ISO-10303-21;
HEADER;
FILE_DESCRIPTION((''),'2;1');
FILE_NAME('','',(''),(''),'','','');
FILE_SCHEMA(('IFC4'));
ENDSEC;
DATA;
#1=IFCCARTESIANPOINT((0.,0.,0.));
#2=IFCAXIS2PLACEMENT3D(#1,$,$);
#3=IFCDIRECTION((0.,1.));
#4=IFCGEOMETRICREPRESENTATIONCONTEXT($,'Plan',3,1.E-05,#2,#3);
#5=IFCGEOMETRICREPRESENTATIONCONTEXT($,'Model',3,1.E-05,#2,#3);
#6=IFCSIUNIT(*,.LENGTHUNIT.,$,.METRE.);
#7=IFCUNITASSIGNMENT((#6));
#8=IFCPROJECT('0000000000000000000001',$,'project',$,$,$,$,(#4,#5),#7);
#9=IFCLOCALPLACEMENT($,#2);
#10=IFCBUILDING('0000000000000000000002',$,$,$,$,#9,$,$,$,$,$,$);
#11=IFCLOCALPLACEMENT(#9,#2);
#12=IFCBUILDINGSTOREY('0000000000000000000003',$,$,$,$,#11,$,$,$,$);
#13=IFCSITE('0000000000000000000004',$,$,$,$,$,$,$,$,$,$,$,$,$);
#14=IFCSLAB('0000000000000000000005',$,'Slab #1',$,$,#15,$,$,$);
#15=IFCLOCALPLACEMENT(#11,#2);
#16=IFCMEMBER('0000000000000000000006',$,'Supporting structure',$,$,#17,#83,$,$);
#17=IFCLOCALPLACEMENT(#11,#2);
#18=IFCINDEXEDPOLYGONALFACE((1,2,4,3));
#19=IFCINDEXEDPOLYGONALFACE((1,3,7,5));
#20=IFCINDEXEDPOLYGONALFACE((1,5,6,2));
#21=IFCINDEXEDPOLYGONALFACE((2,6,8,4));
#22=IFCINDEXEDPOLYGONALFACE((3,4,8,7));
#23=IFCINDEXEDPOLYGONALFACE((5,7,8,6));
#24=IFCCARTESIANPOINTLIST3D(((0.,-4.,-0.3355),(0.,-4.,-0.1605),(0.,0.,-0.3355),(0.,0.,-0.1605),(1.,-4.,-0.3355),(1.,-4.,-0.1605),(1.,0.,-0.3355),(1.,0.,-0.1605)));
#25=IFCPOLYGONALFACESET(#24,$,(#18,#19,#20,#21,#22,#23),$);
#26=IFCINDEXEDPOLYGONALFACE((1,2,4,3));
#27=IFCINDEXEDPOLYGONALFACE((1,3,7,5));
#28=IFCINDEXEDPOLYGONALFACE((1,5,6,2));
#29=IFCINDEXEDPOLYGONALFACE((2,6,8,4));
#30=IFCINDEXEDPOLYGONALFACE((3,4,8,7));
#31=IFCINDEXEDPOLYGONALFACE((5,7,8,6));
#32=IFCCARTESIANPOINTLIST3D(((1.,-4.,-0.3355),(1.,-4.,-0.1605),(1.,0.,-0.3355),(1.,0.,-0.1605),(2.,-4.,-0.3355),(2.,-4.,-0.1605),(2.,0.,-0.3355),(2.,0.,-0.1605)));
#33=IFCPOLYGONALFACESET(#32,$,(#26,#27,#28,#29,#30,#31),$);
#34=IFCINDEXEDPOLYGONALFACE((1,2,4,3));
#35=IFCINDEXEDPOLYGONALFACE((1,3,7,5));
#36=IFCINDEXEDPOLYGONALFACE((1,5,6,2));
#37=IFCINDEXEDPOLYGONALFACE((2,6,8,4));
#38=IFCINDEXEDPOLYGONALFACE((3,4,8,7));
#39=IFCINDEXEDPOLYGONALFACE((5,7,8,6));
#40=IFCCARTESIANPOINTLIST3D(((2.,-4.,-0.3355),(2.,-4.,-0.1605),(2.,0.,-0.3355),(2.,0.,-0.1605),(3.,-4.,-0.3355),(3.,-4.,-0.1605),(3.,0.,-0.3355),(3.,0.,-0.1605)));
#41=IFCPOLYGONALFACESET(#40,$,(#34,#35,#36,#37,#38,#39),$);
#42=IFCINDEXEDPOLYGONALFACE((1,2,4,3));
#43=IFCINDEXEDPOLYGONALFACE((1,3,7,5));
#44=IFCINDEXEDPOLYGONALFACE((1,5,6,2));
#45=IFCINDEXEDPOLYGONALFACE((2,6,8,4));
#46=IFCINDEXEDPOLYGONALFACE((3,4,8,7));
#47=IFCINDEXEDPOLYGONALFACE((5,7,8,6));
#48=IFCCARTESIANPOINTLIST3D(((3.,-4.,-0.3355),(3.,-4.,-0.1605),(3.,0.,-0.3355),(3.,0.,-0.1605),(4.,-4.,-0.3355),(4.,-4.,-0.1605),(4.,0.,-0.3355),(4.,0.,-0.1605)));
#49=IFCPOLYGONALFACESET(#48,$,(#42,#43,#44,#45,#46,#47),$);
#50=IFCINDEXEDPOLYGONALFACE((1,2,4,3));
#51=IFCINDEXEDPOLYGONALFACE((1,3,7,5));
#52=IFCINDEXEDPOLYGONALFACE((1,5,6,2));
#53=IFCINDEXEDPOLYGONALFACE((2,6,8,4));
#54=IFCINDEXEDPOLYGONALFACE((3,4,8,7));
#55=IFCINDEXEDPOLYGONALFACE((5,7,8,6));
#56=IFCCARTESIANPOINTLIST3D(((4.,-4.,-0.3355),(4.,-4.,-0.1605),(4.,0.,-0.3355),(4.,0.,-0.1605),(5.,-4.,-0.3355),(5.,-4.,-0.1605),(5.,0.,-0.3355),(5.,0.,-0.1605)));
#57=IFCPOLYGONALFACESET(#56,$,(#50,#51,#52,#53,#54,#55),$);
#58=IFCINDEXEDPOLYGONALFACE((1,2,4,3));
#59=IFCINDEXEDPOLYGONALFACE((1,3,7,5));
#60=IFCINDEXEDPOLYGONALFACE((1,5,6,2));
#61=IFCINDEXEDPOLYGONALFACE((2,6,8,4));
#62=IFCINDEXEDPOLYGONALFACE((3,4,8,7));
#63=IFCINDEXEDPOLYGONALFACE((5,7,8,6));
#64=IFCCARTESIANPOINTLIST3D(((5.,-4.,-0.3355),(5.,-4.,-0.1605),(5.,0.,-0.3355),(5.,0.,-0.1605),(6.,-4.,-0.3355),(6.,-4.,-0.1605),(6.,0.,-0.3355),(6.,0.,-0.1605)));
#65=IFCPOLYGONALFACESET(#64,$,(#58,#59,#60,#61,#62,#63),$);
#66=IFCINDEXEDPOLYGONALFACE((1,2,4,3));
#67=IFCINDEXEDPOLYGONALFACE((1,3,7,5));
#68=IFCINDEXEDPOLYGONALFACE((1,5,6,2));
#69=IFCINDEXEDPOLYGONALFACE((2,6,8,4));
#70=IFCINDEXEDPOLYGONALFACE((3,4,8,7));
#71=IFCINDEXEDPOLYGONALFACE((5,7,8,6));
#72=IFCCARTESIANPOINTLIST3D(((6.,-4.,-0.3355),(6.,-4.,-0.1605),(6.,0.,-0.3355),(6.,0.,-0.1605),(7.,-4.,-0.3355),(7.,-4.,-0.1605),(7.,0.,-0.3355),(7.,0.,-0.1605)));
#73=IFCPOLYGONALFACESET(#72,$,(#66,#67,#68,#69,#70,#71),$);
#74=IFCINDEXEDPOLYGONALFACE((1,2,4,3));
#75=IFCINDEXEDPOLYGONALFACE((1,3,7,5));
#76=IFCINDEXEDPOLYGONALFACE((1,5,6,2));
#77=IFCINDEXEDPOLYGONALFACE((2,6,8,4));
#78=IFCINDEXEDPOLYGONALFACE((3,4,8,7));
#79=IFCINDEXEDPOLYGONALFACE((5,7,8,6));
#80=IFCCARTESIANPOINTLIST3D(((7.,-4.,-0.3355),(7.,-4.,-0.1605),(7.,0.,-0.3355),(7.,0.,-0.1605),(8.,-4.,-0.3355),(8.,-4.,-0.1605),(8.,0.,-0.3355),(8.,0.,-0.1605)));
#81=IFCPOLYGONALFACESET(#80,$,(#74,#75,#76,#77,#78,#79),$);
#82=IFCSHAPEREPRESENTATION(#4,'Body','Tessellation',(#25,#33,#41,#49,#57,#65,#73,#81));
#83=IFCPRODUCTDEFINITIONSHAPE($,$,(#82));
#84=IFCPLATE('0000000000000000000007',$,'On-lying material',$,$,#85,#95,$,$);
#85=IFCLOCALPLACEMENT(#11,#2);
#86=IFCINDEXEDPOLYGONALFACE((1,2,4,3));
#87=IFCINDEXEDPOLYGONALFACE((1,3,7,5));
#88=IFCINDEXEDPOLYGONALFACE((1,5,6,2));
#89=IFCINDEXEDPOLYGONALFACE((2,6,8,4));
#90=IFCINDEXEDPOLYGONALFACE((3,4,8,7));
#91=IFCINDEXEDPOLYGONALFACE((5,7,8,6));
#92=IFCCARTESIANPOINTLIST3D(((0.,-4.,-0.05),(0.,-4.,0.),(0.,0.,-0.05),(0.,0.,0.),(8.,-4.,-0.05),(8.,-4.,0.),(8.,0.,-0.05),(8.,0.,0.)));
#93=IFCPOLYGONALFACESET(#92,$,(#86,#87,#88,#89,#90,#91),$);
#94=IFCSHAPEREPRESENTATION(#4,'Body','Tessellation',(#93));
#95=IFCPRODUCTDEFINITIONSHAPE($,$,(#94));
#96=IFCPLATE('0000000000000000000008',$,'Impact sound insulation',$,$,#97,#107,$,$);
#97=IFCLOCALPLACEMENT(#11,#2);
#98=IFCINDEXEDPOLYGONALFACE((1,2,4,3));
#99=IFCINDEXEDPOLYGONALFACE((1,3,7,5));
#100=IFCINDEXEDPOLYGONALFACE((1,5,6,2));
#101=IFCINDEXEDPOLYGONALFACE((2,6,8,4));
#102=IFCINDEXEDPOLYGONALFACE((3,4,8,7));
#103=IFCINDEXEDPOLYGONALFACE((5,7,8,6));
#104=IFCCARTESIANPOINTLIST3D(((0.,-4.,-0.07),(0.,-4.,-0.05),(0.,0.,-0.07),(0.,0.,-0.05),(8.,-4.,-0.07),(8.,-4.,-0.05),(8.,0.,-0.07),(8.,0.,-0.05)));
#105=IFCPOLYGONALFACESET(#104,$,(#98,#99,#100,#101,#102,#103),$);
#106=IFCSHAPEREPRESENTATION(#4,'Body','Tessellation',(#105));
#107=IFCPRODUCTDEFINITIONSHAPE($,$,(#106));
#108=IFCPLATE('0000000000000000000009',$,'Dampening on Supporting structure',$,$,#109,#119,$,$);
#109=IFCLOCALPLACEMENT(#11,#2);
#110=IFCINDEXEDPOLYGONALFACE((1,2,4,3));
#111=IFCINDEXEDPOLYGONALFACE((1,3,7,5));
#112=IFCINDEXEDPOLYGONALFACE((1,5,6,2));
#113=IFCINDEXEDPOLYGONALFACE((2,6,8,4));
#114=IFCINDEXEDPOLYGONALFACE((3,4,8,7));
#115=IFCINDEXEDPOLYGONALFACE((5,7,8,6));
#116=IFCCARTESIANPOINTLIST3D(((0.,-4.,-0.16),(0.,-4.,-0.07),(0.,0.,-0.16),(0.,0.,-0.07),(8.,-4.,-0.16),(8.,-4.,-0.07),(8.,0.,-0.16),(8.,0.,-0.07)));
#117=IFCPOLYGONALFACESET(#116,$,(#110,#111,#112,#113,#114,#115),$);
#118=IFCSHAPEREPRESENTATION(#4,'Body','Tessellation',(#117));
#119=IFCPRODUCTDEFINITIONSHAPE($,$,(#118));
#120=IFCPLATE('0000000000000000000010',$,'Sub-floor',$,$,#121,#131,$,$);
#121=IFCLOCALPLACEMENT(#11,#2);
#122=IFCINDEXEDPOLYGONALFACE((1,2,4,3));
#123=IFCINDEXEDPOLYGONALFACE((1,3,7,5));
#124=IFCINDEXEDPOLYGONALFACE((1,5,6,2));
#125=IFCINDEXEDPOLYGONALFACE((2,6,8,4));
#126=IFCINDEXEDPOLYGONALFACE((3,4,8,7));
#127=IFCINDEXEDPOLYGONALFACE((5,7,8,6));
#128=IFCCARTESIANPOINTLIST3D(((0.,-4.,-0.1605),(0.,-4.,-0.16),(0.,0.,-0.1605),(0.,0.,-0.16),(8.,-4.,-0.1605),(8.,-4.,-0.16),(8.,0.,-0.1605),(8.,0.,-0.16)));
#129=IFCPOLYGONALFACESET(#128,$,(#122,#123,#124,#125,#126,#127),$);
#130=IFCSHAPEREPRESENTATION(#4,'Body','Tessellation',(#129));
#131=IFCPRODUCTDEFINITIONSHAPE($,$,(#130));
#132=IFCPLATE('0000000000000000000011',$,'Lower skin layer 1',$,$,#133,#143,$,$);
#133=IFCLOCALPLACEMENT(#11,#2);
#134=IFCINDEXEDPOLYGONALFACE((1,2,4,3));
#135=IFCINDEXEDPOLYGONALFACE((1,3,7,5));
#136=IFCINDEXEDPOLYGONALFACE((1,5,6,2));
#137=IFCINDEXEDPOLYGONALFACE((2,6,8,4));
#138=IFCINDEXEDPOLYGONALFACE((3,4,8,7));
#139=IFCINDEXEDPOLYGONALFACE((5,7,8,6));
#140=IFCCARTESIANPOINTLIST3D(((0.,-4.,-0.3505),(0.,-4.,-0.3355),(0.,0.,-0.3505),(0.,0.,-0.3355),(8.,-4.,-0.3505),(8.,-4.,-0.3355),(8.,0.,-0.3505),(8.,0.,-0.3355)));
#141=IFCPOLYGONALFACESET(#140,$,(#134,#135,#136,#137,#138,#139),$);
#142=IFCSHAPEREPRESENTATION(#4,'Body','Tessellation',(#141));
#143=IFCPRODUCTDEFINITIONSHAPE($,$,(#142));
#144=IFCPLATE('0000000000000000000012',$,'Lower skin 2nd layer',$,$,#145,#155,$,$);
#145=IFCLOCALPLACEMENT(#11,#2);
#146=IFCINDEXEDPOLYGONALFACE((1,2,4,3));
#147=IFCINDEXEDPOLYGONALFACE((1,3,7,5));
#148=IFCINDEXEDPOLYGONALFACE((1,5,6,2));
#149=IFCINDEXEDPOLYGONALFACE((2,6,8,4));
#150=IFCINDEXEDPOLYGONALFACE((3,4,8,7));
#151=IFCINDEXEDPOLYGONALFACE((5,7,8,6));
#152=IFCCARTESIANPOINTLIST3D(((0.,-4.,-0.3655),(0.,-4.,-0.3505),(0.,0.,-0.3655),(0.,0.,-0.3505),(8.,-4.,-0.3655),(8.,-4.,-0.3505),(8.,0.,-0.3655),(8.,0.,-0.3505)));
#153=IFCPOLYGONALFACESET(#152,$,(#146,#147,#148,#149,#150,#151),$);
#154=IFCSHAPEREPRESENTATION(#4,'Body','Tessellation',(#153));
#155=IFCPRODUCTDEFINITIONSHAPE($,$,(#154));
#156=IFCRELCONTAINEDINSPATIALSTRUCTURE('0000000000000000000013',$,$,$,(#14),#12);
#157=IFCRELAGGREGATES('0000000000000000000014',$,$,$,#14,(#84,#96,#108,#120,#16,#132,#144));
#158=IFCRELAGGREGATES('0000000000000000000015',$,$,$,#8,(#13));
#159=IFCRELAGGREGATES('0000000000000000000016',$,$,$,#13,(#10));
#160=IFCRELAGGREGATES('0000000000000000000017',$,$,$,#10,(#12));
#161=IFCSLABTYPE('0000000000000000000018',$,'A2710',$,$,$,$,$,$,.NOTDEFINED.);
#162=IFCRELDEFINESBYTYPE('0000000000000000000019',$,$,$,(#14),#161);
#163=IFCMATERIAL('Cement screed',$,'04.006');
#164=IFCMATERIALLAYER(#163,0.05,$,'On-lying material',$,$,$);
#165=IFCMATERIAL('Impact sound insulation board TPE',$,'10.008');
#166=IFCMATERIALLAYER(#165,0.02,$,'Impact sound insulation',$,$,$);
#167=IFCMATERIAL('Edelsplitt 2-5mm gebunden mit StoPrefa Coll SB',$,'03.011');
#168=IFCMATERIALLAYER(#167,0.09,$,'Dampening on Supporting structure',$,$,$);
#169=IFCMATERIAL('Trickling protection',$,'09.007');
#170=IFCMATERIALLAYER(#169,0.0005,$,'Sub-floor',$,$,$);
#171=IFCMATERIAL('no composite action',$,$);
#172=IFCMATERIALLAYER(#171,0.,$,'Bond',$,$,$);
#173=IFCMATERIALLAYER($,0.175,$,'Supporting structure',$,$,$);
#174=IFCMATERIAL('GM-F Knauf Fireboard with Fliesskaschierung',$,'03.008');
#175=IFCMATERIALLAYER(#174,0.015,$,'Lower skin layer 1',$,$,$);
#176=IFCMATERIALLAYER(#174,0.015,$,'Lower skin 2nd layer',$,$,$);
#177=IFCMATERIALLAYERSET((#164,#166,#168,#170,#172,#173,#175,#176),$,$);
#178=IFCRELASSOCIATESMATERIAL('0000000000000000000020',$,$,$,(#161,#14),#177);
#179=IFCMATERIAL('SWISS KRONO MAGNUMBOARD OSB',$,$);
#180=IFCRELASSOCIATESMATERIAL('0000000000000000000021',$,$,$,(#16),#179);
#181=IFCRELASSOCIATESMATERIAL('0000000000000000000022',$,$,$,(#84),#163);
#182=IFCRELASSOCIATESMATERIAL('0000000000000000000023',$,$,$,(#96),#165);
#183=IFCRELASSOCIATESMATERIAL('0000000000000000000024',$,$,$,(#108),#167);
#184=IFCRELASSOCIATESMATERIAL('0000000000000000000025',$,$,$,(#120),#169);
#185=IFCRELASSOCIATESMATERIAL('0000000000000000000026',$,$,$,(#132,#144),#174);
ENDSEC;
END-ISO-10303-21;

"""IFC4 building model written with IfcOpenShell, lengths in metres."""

from ifc_helpers import new_model, si_unit, direction, frame, frame_2d, origin, origin_with_axes, place, context, project, spatial, rectangle, extrude, material, layer, layer_set, type_object, element, aggregate, save


model = new_model("IFC4")

# Units and contexts
plan_context = context("Plan", 3, precision=1e-05, world=origin(), true_north=direction((0.0, 1.0)))
model_context = context("Model", 3, precision=1e-05, world=origin(), true_north=direction((0.0, 1.0)))
ifc_project = project(units=[si_unit("LENGTHUNIT", "METRE")], contexts=[plan_context, model_context])

# Site, building, storey
site = spatial("IfcSite", under=ifc_project)
building_placement = place(None, origin())
building = spatial("IfcBuilding", under=site, at=building_placement)
storey_placement = place(building_placement, origin())
storey = spatial("IfcBuildingStorey", under=building, at=storey_placement)

# Slab, member, plates
ifc_material_1 = material(Name="Cement screed", Category="04.006")
ifc_layer_1 = layer(ifc_material_1, 0.05, Name="On-lying material")
ifc_material_2 = material(Name="Impact sound insulation board TPE", Category="10.008")
ifc_layer_2 = layer(ifc_material_2, 0.02, Name="Impact sound insulation")
ifc_material_3 = material(Name="Edelsplitt 2-5mm gebunden mit StoPrefa Coll SB", Category="03.011")
ifc_layer_3 = layer(ifc_material_3, 0.09, Name="Dampening on Supporting structure")
ifc_material_4 = material(Name="Trickling protection", Category="09.007")
ifc_layer_4 = layer(ifc_material_4, 0.0005, Name="Sub-floor")
ifc_material_5 = material(Name="no composite action")
ifc_layer_5 = layer(ifc_material_5, 0.0, Name="Bond")
ifc_layer_6 = layer(None, 0.175, Name="Supporting structure")
ifc_material_6 = material(Name="GM-F Knauf Fireboard with Fliesskaschierung", Category="03.008")
ifc_layer_7 = layer(ifc_material_6, 0.015, Name="Lower skin layer 1")
ifc_layer_8 = layer(ifc_material_6, 0.015, Name="Lower skin 2nd layer")
ifc_layer_set = layer_set([ifc_layer_1, ifc_layer_2, ifc_layer_3, ifc_layer_4, ifc_layer_5, ifc_layer_6, ifc_layer_7, ifc_layer_8])
slab_type = type_object("IfcSlabType", Name="A2710", PredefinedType="NOTDEFINED", material=ifc_layer_set)
slab_placement = place(None, frame((0.0, 0.0, 0.0), z_axis=(0.0, 0.0, -1.0), x_axis=(1.0, 0.0, 0.0)))
slab = element("IfcSlab", 1, at=slab_placement, inside=storey, type_object=slab_type, material=ifc_layer_set, Name="Slab #1")
ifc_material_7 = material(Name="SWISS KRONO MAGNUMBOARD OSB")
member_placement = place(slab_placement, origin())
member = element("IfcMember", 2, at=member_placement, material=ifc_material_7, Name="Supporting structure", context=plan_context, shape_type="SweptSolid", body=[
    extrude(rectangle(XDim=1.0, YDim=0.175, at=frame_2d((0.5, 0.0875), x_axis=(1.0, 0.0))), frame((0.0, 4.0, 0.1605), z_axis=(0.0, -1.0, 0.0), x_axis=(1.0, 0.0, 0.0)), (0.0, 0.0, 1.0), 4.0),
    extrude(rectangle(XDim=1.0, YDim=0.175, at=frame_2d((0.5, 0.0875), x_axis=(1.0, 0.0))), frame((1.0, 4.0, 0.1605), z_axis=(0.0, -1.0, 0.0), x_axis=(1.0, 0.0, 0.0)), (0.0, 0.0, 1.0), 4.0),
    extrude(rectangle(XDim=1.0, YDim=0.175, at=frame_2d((0.5, 0.0875), x_axis=(1.0, 0.0))), frame((2.0, 4.0, 0.1605), z_axis=(0.0, -1.0, 0.0), x_axis=(1.0, 0.0, 0.0)), (0.0, 0.0, 1.0), 4.0),
    extrude(rectangle(XDim=1.0, YDim=0.175, at=frame_2d((0.5, 0.0875), x_axis=(1.0, 0.0))), frame((3.0, 4.0, 0.1605), z_axis=(0.0, -1.0, 0.0), x_axis=(1.0, 0.0, 0.0)), (0.0, 0.0, 1.0), 4.0),
    extrude(rectangle(XDim=1.0, YDim=0.175, at=frame_2d((0.5, 0.0875), x_axis=(1.0, 0.0))), frame((4.0, 4.0, 0.1605), z_axis=(0.0, -1.0, 0.0), x_axis=(1.0, 0.0, 0.0)), (0.0, 0.0, 1.0), 4.0),
    extrude(rectangle(XDim=1.0, YDim=0.175, at=frame_2d((0.5, 0.0875), x_axis=(1.0, 0.0))), frame((5.0, 4.0, 0.1605), z_axis=(0.0, -1.0, 0.0), x_axis=(1.0, 0.0, 0.0)), (0.0, 0.0, 1.0), 4.0),
    extrude(rectangle(XDim=1.0, YDim=0.175, at=frame_2d((0.5, 0.0875), x_axis=(1.0, 0.0))), frame((6.0, 4.0, 0.1605), z_axis=(0.0, -1.0, 0.0), x_axis=(1.0, 0.0, 0.0)), (0.0, 0.0, 1.0), 4.0),
    extrude(rectangle(XDim=1.0, YDim=0.175, at=frame_2d((0.5, 0.0875), x_axis=(1.0, 0.0))), frame((7.0, 4.0, 0.1605), z_axis=(0.0, -1.0, 0.0), x_axis=(1.0, 0.0, 0.0)), (0.0, 0.0, 1.0), 4.0),
])
plate_1_placement = place(slab_placement, origin())
plate_1 = element("IfcPlate", 3, at=plate_1_placement, material=ifc_material_1, Name="On-lying material", context=plan_context, shape_type="SweptSolid", body=[
    extrude(rectangle(XDim=8.0, YDim=4.0, at=frame_2d((4.0, 2.0), x_axis=(1.0, 0.0))), origin_with_axes(), (0.0, 0.0, 1.0), 0.05),
])
plate_2_placement = place(slab_placement, origin())
plate_2 = element("IfcPlate", 4, at=plate_2_placement, material=ifc_material_2, Name="Impact sound insulation", context=plan_context, shape_type="SweptSolid", body=[
    extrude(rectangle(XDim=8.0, YDim=4.0, at=frame_2d((4.0, 2.0), x_axis=(1.0, 0.0))), frame((0.0, 0.0, 0.05), z_axis=(0.0, 0.0, 1.0), x_axis=(1.0, 0.0, 0.0)), (0.0, 0.0, 1.0), 0.02),
])
plate_3_placement = place(slab_placement, origin())
plate_3 = element("IfcPlate", 5, at=plate_3_placement, material=ifc_material_3, Name="Dampening on Supporting structure", context=plan_context, shape_type="SweptSolid", body=[
    extrude(rectangle(XDim=8.0, YDim=4.0, at=frame_2d((4.0, 2.0), x_axis=(1.0, 0.0))), frame((0.0, 0.0, 0.07), z_axis=(0.0, 0.0, 1.0), x_axis=(1.0, 0.0, 0.0)), (0.0, 0.0, 1.0), 0.09),
])
plate_4_placement = place(slab_placement, origin())
plate_4 = element("IfcPlate", 6, at=plate_4_placement, material=ifc_material_4, Name="Sub-floor", context=plan_context, shape_type="SweptSolid", body=[
    extrude(rectangle(XDim=8.0, YDim=4.0, at=frame_2d((4.0, 2.0), x_axis=(1.0, 0.0))), frame((0.0, 0.0, 0.16), z_axis=(0.0, 0.0, 1.0), x_axis=(1.0, 0.0, 0.0)), (0.0, 0.0, 1.0), 0.0005),
])
plate_5_placement = place(slab_placement, origin())
plate_5 = element("IfcPlate", 7, at=plate_5_placement, material=ifc_material_6, Name="Lower skin layer 1", context=plan_context, shape_type="SweptSolid", body=[
    extrude(rectangle(XDim=8.0, YDim=4.0, at=frame_2d((4.0, 2.0), x_axis=(1.0, 0.0))), frame((0.0, 0.0, 0.3355), z_axis=(0.0, 0.0, 1.0), x_axis=(1.0, 0.0, 0.0)), (0.0, 0.0, 1.0), 0.015),
])
plate_6_placement = place(slab_placement, origin())
plate_6 = element("IfcPlate", 8, at=plate_6_placement, material=ifc_material_6, Name="Lower skin 2nd layer", context=plan_context, shape_type="SweptSolid", body=[
    extrude(rectangle(XDim=8.0, YDim=4.0, at=frame_2d((4.0, 2.0), x_axis=(1.0, 0.0))), frame((0.0, 0.0, 0.3505), z_axis=(0.0, 0.0, 1.0), x_axis=(1.0, 0.0, 0.0)), (0.0, 0.0, 1.0), 0.015),
])
aggregate(slab, [plate_1, plate_2, plate_3, plate_4, member, plate_5, plate_6])

save(model, "model.ifc")
